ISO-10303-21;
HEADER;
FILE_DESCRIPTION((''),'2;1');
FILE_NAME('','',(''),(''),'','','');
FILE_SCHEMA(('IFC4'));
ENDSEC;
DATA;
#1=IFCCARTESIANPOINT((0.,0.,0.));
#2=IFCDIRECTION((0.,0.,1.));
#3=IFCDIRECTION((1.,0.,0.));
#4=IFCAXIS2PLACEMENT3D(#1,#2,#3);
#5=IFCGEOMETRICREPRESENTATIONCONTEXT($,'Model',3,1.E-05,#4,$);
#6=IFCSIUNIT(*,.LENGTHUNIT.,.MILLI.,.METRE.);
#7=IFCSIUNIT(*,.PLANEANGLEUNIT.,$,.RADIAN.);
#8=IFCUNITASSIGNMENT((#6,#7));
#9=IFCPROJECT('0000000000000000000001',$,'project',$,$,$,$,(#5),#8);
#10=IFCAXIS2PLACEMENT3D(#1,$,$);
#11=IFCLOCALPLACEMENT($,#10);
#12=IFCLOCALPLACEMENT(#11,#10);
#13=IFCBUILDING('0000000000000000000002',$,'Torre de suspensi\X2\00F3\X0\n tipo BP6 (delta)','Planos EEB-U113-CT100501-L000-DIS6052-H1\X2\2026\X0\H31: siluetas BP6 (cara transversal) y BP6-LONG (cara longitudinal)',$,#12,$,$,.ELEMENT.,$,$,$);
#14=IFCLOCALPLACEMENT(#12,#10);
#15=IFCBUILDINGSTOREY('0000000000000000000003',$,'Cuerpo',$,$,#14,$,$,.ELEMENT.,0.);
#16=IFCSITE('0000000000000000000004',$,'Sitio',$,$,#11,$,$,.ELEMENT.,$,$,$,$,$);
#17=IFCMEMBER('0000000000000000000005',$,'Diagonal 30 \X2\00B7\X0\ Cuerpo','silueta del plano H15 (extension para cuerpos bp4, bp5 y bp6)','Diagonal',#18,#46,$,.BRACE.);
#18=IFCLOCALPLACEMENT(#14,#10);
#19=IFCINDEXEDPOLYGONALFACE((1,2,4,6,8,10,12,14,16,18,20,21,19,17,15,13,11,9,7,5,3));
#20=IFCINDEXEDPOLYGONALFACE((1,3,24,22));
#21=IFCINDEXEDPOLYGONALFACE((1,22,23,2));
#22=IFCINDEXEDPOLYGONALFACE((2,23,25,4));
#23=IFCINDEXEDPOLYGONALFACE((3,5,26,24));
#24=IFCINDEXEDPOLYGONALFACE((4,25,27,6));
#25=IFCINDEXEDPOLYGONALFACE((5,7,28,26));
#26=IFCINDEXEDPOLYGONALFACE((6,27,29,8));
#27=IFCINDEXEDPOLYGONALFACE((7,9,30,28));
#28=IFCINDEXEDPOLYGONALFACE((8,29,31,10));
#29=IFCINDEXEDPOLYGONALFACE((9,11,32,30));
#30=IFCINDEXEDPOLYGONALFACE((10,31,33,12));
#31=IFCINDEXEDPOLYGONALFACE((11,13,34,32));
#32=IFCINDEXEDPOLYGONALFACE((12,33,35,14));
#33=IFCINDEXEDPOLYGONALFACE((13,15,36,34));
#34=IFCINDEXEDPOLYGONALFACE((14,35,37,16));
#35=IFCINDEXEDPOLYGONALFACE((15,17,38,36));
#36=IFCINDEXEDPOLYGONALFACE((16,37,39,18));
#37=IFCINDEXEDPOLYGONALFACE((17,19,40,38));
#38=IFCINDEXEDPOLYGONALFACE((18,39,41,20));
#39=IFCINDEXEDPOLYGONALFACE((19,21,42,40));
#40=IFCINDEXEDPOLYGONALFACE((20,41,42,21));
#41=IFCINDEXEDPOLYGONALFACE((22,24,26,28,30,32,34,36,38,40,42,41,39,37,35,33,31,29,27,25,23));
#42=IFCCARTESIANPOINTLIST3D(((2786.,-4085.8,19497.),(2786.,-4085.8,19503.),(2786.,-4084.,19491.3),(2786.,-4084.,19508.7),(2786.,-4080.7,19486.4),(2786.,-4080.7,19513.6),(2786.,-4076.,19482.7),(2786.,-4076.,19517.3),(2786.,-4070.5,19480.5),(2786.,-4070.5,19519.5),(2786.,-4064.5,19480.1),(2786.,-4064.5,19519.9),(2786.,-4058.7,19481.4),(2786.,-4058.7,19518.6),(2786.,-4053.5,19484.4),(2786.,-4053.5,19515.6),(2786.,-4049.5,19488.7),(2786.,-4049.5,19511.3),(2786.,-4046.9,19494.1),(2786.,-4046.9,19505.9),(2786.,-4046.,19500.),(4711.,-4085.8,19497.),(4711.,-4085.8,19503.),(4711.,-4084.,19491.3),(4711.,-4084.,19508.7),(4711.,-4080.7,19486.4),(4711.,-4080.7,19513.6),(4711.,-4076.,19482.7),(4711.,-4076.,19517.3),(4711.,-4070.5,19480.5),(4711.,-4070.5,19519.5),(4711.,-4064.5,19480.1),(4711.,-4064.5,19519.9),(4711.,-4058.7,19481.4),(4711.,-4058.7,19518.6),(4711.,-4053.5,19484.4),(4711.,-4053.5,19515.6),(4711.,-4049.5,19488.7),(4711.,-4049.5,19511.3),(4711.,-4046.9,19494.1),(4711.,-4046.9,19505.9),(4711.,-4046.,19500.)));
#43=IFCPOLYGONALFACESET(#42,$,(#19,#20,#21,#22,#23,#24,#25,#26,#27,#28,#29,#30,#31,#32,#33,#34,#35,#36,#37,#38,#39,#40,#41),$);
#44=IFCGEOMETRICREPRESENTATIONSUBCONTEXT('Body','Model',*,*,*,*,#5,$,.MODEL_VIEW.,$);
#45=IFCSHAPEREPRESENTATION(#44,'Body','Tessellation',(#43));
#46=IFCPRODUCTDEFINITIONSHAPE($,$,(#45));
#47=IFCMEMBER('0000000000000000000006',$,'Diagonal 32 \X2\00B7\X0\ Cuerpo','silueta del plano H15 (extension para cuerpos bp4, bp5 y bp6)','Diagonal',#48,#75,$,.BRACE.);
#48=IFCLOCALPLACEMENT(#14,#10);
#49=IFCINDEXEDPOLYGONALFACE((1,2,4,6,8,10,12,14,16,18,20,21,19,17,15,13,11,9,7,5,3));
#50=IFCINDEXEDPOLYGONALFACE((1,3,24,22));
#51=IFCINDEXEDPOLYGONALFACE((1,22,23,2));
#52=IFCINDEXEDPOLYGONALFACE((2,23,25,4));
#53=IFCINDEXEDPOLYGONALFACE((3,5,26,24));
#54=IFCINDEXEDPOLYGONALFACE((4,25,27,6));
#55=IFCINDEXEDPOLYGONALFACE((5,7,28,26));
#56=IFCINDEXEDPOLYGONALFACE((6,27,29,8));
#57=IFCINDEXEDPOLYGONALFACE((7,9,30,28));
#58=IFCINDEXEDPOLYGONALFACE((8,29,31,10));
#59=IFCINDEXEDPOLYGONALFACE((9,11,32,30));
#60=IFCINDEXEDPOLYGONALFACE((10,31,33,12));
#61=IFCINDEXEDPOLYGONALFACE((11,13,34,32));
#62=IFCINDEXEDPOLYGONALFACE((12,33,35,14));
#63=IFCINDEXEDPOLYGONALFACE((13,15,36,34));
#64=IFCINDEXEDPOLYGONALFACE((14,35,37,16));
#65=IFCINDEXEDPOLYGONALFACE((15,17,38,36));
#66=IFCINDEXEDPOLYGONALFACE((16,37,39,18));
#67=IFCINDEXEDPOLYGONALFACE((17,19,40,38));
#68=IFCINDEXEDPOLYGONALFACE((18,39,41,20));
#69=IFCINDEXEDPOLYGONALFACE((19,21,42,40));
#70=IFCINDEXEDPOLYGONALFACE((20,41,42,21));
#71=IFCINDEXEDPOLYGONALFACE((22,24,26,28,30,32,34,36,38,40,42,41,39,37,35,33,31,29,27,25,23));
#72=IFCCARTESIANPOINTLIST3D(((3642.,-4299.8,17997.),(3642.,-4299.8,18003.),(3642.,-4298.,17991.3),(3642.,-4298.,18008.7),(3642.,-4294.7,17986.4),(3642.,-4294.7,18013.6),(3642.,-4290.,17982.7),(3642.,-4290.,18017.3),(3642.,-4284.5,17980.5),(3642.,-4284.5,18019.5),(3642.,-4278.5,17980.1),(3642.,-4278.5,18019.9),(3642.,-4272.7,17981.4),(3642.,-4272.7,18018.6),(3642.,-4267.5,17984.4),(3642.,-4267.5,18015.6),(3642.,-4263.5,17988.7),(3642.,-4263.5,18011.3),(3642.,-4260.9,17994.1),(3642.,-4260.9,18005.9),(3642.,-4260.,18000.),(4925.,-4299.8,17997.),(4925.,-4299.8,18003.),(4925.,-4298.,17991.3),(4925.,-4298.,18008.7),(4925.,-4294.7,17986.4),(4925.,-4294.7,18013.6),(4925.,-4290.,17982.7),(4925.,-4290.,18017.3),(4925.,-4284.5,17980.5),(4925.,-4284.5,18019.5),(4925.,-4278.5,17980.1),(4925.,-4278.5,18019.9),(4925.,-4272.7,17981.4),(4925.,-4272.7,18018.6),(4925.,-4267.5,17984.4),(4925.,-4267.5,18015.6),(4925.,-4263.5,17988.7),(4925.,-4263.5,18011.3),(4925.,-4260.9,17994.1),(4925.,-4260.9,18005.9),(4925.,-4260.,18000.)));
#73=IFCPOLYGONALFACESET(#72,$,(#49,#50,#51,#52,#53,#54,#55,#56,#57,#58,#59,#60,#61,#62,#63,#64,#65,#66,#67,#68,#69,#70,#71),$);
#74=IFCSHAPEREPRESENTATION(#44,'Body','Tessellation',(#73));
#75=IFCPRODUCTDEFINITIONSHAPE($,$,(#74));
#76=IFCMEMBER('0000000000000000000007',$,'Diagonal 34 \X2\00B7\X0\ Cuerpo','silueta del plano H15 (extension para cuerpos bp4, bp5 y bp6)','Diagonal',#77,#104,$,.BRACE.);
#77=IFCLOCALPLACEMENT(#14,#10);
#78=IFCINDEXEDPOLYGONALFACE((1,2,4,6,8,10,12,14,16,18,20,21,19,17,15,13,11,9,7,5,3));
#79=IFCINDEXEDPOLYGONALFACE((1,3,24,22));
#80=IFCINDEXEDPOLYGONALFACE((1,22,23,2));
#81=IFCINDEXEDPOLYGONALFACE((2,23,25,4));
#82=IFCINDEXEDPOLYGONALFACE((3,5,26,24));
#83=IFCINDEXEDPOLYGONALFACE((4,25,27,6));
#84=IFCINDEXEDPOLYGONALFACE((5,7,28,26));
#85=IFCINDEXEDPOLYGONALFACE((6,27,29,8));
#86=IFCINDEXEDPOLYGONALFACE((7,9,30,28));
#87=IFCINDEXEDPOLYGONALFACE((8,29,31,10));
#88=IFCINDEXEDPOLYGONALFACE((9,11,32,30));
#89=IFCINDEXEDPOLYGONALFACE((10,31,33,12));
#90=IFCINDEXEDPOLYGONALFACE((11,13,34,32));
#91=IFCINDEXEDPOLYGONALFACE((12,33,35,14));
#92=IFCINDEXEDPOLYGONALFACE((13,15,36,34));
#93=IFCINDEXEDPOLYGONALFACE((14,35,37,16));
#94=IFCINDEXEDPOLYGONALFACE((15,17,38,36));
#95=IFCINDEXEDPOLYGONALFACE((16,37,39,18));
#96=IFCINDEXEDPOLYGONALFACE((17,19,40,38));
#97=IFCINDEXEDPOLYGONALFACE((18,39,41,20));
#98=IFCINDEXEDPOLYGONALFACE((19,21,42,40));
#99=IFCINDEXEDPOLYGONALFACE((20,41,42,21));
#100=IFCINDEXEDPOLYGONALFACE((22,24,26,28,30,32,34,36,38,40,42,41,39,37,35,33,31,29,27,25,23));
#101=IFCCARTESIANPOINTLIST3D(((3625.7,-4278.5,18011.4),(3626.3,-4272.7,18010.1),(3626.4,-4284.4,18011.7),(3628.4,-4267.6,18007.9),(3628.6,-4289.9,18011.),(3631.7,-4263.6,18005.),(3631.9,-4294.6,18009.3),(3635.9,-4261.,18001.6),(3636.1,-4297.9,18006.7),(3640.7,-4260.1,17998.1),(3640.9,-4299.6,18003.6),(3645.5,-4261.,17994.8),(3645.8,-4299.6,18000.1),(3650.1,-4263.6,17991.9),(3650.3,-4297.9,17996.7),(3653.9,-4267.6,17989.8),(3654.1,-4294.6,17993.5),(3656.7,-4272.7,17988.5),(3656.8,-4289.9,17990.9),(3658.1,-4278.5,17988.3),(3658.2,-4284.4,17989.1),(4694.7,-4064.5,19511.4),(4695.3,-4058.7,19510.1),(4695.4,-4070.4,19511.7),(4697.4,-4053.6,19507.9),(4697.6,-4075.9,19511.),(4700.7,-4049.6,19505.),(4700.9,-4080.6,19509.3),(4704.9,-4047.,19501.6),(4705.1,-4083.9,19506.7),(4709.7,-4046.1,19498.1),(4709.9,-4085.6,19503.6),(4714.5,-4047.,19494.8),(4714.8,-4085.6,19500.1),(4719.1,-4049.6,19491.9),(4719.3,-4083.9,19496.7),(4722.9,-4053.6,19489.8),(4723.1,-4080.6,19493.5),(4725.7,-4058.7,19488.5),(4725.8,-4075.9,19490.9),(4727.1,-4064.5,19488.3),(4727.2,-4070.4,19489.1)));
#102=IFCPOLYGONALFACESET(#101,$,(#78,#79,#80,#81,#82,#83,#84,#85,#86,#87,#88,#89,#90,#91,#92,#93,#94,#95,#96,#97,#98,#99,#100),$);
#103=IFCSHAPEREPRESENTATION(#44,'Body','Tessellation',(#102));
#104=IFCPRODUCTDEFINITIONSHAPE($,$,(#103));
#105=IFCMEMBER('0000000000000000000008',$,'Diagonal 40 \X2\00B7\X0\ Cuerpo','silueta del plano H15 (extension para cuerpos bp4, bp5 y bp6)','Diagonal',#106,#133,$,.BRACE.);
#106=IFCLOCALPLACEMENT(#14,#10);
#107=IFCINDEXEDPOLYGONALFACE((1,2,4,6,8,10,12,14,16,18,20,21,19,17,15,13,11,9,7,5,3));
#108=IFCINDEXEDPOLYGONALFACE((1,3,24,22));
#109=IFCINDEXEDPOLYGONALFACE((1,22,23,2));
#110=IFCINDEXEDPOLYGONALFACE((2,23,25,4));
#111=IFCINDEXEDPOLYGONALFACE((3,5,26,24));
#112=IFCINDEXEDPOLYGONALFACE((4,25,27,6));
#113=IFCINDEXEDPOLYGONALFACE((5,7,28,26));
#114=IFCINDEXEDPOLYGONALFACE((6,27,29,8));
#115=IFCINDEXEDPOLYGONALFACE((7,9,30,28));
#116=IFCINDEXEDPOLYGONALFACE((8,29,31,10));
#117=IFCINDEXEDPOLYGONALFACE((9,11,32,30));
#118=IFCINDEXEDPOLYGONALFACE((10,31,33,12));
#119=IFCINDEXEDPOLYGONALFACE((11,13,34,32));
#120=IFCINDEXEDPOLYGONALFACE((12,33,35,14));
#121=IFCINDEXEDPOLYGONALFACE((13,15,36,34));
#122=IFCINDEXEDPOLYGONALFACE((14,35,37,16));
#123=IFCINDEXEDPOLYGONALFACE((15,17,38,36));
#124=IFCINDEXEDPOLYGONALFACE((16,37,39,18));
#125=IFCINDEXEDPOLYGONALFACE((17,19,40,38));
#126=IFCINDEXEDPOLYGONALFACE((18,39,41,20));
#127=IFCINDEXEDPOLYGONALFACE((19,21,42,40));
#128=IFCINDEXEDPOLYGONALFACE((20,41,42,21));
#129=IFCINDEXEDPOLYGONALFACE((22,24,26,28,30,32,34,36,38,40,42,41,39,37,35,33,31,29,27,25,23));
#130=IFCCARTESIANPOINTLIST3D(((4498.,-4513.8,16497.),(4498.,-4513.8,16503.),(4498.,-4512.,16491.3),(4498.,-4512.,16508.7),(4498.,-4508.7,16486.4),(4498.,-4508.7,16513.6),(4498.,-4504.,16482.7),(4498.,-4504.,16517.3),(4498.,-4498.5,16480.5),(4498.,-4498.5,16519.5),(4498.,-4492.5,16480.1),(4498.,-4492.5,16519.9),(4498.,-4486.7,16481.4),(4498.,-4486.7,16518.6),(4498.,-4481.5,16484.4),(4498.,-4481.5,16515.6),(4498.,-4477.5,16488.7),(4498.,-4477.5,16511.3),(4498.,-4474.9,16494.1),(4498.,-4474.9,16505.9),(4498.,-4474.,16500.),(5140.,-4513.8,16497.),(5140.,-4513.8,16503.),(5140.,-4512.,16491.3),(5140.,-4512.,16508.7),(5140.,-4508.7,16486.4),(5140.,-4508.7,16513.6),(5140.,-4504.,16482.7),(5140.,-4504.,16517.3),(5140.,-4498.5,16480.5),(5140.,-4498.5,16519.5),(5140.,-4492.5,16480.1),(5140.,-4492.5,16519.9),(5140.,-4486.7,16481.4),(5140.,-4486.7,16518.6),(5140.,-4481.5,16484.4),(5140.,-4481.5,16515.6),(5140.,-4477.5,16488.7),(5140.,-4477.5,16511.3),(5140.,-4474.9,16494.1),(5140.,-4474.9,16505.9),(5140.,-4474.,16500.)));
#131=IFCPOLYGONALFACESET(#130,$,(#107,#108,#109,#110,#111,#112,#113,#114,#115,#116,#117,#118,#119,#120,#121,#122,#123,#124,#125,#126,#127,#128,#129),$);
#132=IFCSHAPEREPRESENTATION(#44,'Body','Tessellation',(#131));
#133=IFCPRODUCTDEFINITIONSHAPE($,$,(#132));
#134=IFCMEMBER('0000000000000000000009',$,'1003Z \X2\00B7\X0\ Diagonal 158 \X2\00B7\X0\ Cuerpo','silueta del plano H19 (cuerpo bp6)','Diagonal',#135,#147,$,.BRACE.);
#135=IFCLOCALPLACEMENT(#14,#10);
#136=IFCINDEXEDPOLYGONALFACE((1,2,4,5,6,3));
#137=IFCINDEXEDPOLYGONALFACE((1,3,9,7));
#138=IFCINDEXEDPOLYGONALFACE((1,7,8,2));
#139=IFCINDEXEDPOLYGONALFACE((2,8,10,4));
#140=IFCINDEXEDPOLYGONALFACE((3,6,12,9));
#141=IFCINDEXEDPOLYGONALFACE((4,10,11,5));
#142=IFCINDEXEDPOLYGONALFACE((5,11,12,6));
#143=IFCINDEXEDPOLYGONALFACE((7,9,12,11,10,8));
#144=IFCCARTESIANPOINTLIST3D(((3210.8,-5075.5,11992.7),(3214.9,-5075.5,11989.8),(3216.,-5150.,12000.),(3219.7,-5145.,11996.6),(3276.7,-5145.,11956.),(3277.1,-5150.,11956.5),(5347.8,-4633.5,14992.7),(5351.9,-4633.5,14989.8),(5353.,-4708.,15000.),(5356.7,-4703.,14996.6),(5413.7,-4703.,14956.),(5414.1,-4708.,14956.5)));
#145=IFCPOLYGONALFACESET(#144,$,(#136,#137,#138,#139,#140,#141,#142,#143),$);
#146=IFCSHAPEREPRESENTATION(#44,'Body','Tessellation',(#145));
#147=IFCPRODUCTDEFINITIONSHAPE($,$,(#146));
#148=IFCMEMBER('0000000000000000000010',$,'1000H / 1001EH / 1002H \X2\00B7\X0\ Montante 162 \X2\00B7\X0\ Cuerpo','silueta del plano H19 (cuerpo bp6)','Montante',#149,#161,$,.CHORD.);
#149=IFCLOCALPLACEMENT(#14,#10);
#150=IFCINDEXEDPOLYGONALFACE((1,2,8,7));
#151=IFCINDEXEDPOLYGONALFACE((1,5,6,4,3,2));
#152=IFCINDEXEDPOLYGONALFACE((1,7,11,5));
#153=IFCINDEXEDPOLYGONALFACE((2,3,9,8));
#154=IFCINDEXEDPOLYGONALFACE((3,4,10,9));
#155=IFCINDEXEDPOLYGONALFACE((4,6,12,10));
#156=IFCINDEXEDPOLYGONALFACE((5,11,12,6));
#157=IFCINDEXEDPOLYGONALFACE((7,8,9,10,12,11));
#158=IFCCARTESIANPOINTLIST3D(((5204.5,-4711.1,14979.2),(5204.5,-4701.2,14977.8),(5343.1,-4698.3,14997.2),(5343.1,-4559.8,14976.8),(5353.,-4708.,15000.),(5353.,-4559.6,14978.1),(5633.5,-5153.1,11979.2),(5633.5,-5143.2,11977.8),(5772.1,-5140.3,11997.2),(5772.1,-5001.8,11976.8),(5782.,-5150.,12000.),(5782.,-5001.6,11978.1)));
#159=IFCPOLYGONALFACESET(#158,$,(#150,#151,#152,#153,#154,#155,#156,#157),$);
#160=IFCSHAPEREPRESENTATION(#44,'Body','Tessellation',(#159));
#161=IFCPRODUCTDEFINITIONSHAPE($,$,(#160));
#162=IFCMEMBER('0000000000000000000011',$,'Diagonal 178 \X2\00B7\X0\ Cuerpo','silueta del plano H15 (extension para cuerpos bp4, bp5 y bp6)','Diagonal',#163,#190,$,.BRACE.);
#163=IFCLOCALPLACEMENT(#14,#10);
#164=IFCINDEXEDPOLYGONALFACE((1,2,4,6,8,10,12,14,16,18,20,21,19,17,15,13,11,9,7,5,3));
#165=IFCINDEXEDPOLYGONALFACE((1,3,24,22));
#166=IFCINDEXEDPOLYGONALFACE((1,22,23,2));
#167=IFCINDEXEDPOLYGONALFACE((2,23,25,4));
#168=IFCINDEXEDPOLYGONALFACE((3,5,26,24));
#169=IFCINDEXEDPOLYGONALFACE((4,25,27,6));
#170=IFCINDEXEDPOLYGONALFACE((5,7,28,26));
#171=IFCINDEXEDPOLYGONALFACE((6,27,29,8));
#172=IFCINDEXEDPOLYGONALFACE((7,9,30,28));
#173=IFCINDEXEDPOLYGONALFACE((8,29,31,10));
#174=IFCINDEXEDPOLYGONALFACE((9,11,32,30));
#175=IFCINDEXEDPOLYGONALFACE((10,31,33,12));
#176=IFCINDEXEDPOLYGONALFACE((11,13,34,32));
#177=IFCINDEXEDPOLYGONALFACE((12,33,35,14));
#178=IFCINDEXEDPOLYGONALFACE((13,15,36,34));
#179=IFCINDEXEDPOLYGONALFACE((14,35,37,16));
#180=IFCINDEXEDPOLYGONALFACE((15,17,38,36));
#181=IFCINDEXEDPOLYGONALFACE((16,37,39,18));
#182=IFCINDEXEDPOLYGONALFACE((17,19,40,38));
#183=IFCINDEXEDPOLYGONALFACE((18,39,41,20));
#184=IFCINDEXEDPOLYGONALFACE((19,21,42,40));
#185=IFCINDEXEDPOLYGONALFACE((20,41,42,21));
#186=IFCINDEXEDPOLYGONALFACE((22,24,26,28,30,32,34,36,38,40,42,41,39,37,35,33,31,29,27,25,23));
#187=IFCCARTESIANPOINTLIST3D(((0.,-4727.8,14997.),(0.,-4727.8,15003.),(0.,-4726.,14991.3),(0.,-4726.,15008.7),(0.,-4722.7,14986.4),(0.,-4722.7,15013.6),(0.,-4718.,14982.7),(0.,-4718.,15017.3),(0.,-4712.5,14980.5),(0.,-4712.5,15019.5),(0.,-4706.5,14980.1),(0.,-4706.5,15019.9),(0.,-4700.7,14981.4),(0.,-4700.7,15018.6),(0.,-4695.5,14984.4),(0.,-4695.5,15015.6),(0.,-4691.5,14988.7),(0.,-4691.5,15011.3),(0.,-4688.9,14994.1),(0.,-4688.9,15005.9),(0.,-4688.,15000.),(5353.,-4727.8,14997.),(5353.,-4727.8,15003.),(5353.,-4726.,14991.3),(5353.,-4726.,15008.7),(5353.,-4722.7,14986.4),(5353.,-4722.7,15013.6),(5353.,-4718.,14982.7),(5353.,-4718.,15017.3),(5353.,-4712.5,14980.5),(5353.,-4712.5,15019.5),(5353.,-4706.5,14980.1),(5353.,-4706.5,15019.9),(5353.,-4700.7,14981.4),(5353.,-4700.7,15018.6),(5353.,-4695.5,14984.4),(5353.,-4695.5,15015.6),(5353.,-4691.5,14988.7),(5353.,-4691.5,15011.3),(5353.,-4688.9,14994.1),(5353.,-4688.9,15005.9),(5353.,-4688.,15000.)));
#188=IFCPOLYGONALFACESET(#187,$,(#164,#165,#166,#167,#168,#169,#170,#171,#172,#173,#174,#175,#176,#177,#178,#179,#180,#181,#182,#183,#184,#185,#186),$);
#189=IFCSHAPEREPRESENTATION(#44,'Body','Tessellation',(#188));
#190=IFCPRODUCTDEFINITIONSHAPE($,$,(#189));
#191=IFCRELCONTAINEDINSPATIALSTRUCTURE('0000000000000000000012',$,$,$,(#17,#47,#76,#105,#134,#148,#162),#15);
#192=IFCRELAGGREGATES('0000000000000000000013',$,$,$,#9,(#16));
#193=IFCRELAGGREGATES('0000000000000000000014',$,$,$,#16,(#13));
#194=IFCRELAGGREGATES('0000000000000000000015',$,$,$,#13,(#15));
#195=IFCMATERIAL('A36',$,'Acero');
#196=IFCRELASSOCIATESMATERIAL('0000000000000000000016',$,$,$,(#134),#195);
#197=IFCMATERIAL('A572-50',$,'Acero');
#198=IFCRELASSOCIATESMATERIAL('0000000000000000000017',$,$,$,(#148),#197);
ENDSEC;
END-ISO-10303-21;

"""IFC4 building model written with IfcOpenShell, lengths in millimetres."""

from ifc_helpers import new_model, si_unit, frame, frame_2d, origin, origin_with_axes, place, context, subcontext, project, spatial, circle, l_section, extrude, material, element, save


model = new_model("IFC4")

# Units and contexts
model_context = context("Model", 3, precision=1e-05, world=origin_with_axes())
body_context = subcontext(model_context, "Body", "Model", "MODEL_VIEW")
ifc_project = project(units=[si_unit("LENGTHUNIT", "METRE", prefix="MILLI"), si_unit("PLANEANGLEUNIT", "RADIAN")], contexts=[model_context])

# Site, building, storey
site_placement = place(None, origin())
site = spatial("IfcSite", under=ifc_project, at=site_placement, Name="Sitio", CompositionType="ELEMENT")
building_placement = place(site_placement, origin())
building = spatial("IfcBuilding", under=site, at=building_placement, Name="Torre de suspensión tipo BP6 (delta)", Description="Planos EEB-U113-CT100501-L000-DIS6052-H1…H31: siluetas BP6 (cara transversal) y BP6-LONG (cara longitudinal)", CompositionType="ELEMENT")
storey_placement = place(building_placement, origin())
storey = spatial("IfcBuildingStorey", under=building, at=storey_placement, Name="Cuerpo", CompositionType="ELEMENT", Elevation=0.0)

# Members
member_1_placement = place(storey_placement, frame((2786.0, -4066.0, 19500.0), z_axis=(1.0, 0.0, 0.0), x_axis=(0.0, 1.0, 0.0)))
element("IfcMember", 1, at=member_1_placement, inside=storey, Name="Diagonal 30 · Cuerpo", Description="silueta del plano H15 (extension para cuerpos bp4, bp5 y bp6)", ObjectType="Diagonal", PredefinedType="BRACE", context=body_context, shape_type="SweptSolid", body=[
    extrude(circle(Radius=20.0), None, (0.0, 0.0, 1.0), 1925.0),
])
member_2_placement = place(storey_placement, frame((3642.0, -4280.0, 18000.0), z_axis=(1.0, 0.0, 0.0), x_axis=(0.0, 1.0, 0.0)))
element("IfcMember", 2, at=member_2_placement, inside=storey, Name="Diagonal 32 · Cuerpo", Description="silueta del plano H15 (extension para cuerpos bp4, bp5 y bp6)", ObjectType="Diagonal", PredefinedType="BRACE", context=body_context, shape_type="SweptSolid", body=[
    extrude(circle(Radius=20.0), None, (0.0, 0.0, 1.0), 1283.0),
])
member_3_placement = place(storey_placement, frame((3642.0, -4280.0, 18000.0), z_axis=(0.576487, 0.115405, 0.808915), x_axis=(-0.066977, 0.993318, -0.093981)))
element("IfcMember", 3, at=member_3_placement, inside=storey, Name="Diagonal 34 · Cuerpo", Description="silueta del plano H15 (extension para cuerpos bp4, bp5 y bp6)", ObjectType="Diagonal", PredefinedType="BRACE", context=body_context, shape_type="SweptSolid", body=[
    extrude(circle(Radius=20.0), None, (0.0, 0.0, 1.0), 1854.3),
])
member_4_placement = place(storey_placement, frame((4498.0, -4494.0, 16500.0), z_axis=(1.0, 0.0, 0.0), x_axis=(0.0, 1.0, 0.0)))
element("IfcMember", 4, at=member_4_placement, inside=storey, Name="Diagonal 40 · Cuerpo", Description="silueta del plano H15 (extension para cuerpos bp4, bp5 y bp6)", ObjectType="Diagonal", PredefinedType="BRACE", context=body_context, shape_type="SweptSolid", body=[
    extrude(circle(Radius=20.0), None, (0.0, 0.0, 1.0), 642.0),
])
ifc_material_1 = material(Name="A36", Category="Acero")
member_5_placement = place(storey_placement, frame((5353.0, -4708.0, 15000.0), z_axis=(-0.576052, -0.119146, -0.808683), x_axis=(-0.069127, 0.992877, -0.097043)))
element("IfcMember", 5, at=member_5_placement, inside=storey, material=ifc_material_1, Name="1003Z · Diagonal 158 · Cuerpo", Description="silueta del plano H19 (cuerpo bp6)", ObjectType="Diagonal", PredefinedType="BRACE", context=body_context, shape_type="SweptSolid", body=[
    extrude(l_section(Depth=75.0, Width=75.0, Thickness=5.0, at=frame_2d((37.5, 37.5))), None, (0.0, 0.0, 1.0), 3709.7),
])
ifc_material_2 = material(Name="A572-50", Category="Acero")
member_6_placement = place(storey_placement, frame((5353.0, -4708.0, 15000.0), z_axis=(0.140078, -0.144323, -0.979566), x_axis=(-0.99014, -0.020418, -0.138582)))
element("IfcMember", 6, at=member_6_placement, inside=storey, material=ifc_material_2, Name="1000H / 1001EH / 1002H · Montante 162 · Cuerpo", Description="silueta del plano H19 (cuerpo bp6)", ObjectType="Montante", PredefinedType="CHORD", context=body_context, shape_type="SweptSolid", body=[
    extrude(l_section(Depth=150.0, Width=150.0, Thickness=10.0, at=frame_2d((75.0, 75.0))), None, (0.0, 0.0, 1.0), 3062.6),
])
member_7_placement = place(storey_placement, frame((5353.0, -4708.0, 15000.0), z_axis=(-1.0, 0.0, 0.0), x_axis=(0.0, 1.0, 0.0)))
element("IfcMember", 7, at=member_7_placement, inside=storey, Name="Diagonal 178 · Cuerpo", Description="silueta del plano H15 (extension para cuerpos bp4, bp5 y bp6)", ObjectType="Diagonal", PredefinedType="BRACE", context=body_context, shape_type="SweptSolid", body=[
    extrude(circle(Radius=20.0), None, (0.0, 0.0, 1.0), 5353.0),
])

save(model, "model.ifc")
